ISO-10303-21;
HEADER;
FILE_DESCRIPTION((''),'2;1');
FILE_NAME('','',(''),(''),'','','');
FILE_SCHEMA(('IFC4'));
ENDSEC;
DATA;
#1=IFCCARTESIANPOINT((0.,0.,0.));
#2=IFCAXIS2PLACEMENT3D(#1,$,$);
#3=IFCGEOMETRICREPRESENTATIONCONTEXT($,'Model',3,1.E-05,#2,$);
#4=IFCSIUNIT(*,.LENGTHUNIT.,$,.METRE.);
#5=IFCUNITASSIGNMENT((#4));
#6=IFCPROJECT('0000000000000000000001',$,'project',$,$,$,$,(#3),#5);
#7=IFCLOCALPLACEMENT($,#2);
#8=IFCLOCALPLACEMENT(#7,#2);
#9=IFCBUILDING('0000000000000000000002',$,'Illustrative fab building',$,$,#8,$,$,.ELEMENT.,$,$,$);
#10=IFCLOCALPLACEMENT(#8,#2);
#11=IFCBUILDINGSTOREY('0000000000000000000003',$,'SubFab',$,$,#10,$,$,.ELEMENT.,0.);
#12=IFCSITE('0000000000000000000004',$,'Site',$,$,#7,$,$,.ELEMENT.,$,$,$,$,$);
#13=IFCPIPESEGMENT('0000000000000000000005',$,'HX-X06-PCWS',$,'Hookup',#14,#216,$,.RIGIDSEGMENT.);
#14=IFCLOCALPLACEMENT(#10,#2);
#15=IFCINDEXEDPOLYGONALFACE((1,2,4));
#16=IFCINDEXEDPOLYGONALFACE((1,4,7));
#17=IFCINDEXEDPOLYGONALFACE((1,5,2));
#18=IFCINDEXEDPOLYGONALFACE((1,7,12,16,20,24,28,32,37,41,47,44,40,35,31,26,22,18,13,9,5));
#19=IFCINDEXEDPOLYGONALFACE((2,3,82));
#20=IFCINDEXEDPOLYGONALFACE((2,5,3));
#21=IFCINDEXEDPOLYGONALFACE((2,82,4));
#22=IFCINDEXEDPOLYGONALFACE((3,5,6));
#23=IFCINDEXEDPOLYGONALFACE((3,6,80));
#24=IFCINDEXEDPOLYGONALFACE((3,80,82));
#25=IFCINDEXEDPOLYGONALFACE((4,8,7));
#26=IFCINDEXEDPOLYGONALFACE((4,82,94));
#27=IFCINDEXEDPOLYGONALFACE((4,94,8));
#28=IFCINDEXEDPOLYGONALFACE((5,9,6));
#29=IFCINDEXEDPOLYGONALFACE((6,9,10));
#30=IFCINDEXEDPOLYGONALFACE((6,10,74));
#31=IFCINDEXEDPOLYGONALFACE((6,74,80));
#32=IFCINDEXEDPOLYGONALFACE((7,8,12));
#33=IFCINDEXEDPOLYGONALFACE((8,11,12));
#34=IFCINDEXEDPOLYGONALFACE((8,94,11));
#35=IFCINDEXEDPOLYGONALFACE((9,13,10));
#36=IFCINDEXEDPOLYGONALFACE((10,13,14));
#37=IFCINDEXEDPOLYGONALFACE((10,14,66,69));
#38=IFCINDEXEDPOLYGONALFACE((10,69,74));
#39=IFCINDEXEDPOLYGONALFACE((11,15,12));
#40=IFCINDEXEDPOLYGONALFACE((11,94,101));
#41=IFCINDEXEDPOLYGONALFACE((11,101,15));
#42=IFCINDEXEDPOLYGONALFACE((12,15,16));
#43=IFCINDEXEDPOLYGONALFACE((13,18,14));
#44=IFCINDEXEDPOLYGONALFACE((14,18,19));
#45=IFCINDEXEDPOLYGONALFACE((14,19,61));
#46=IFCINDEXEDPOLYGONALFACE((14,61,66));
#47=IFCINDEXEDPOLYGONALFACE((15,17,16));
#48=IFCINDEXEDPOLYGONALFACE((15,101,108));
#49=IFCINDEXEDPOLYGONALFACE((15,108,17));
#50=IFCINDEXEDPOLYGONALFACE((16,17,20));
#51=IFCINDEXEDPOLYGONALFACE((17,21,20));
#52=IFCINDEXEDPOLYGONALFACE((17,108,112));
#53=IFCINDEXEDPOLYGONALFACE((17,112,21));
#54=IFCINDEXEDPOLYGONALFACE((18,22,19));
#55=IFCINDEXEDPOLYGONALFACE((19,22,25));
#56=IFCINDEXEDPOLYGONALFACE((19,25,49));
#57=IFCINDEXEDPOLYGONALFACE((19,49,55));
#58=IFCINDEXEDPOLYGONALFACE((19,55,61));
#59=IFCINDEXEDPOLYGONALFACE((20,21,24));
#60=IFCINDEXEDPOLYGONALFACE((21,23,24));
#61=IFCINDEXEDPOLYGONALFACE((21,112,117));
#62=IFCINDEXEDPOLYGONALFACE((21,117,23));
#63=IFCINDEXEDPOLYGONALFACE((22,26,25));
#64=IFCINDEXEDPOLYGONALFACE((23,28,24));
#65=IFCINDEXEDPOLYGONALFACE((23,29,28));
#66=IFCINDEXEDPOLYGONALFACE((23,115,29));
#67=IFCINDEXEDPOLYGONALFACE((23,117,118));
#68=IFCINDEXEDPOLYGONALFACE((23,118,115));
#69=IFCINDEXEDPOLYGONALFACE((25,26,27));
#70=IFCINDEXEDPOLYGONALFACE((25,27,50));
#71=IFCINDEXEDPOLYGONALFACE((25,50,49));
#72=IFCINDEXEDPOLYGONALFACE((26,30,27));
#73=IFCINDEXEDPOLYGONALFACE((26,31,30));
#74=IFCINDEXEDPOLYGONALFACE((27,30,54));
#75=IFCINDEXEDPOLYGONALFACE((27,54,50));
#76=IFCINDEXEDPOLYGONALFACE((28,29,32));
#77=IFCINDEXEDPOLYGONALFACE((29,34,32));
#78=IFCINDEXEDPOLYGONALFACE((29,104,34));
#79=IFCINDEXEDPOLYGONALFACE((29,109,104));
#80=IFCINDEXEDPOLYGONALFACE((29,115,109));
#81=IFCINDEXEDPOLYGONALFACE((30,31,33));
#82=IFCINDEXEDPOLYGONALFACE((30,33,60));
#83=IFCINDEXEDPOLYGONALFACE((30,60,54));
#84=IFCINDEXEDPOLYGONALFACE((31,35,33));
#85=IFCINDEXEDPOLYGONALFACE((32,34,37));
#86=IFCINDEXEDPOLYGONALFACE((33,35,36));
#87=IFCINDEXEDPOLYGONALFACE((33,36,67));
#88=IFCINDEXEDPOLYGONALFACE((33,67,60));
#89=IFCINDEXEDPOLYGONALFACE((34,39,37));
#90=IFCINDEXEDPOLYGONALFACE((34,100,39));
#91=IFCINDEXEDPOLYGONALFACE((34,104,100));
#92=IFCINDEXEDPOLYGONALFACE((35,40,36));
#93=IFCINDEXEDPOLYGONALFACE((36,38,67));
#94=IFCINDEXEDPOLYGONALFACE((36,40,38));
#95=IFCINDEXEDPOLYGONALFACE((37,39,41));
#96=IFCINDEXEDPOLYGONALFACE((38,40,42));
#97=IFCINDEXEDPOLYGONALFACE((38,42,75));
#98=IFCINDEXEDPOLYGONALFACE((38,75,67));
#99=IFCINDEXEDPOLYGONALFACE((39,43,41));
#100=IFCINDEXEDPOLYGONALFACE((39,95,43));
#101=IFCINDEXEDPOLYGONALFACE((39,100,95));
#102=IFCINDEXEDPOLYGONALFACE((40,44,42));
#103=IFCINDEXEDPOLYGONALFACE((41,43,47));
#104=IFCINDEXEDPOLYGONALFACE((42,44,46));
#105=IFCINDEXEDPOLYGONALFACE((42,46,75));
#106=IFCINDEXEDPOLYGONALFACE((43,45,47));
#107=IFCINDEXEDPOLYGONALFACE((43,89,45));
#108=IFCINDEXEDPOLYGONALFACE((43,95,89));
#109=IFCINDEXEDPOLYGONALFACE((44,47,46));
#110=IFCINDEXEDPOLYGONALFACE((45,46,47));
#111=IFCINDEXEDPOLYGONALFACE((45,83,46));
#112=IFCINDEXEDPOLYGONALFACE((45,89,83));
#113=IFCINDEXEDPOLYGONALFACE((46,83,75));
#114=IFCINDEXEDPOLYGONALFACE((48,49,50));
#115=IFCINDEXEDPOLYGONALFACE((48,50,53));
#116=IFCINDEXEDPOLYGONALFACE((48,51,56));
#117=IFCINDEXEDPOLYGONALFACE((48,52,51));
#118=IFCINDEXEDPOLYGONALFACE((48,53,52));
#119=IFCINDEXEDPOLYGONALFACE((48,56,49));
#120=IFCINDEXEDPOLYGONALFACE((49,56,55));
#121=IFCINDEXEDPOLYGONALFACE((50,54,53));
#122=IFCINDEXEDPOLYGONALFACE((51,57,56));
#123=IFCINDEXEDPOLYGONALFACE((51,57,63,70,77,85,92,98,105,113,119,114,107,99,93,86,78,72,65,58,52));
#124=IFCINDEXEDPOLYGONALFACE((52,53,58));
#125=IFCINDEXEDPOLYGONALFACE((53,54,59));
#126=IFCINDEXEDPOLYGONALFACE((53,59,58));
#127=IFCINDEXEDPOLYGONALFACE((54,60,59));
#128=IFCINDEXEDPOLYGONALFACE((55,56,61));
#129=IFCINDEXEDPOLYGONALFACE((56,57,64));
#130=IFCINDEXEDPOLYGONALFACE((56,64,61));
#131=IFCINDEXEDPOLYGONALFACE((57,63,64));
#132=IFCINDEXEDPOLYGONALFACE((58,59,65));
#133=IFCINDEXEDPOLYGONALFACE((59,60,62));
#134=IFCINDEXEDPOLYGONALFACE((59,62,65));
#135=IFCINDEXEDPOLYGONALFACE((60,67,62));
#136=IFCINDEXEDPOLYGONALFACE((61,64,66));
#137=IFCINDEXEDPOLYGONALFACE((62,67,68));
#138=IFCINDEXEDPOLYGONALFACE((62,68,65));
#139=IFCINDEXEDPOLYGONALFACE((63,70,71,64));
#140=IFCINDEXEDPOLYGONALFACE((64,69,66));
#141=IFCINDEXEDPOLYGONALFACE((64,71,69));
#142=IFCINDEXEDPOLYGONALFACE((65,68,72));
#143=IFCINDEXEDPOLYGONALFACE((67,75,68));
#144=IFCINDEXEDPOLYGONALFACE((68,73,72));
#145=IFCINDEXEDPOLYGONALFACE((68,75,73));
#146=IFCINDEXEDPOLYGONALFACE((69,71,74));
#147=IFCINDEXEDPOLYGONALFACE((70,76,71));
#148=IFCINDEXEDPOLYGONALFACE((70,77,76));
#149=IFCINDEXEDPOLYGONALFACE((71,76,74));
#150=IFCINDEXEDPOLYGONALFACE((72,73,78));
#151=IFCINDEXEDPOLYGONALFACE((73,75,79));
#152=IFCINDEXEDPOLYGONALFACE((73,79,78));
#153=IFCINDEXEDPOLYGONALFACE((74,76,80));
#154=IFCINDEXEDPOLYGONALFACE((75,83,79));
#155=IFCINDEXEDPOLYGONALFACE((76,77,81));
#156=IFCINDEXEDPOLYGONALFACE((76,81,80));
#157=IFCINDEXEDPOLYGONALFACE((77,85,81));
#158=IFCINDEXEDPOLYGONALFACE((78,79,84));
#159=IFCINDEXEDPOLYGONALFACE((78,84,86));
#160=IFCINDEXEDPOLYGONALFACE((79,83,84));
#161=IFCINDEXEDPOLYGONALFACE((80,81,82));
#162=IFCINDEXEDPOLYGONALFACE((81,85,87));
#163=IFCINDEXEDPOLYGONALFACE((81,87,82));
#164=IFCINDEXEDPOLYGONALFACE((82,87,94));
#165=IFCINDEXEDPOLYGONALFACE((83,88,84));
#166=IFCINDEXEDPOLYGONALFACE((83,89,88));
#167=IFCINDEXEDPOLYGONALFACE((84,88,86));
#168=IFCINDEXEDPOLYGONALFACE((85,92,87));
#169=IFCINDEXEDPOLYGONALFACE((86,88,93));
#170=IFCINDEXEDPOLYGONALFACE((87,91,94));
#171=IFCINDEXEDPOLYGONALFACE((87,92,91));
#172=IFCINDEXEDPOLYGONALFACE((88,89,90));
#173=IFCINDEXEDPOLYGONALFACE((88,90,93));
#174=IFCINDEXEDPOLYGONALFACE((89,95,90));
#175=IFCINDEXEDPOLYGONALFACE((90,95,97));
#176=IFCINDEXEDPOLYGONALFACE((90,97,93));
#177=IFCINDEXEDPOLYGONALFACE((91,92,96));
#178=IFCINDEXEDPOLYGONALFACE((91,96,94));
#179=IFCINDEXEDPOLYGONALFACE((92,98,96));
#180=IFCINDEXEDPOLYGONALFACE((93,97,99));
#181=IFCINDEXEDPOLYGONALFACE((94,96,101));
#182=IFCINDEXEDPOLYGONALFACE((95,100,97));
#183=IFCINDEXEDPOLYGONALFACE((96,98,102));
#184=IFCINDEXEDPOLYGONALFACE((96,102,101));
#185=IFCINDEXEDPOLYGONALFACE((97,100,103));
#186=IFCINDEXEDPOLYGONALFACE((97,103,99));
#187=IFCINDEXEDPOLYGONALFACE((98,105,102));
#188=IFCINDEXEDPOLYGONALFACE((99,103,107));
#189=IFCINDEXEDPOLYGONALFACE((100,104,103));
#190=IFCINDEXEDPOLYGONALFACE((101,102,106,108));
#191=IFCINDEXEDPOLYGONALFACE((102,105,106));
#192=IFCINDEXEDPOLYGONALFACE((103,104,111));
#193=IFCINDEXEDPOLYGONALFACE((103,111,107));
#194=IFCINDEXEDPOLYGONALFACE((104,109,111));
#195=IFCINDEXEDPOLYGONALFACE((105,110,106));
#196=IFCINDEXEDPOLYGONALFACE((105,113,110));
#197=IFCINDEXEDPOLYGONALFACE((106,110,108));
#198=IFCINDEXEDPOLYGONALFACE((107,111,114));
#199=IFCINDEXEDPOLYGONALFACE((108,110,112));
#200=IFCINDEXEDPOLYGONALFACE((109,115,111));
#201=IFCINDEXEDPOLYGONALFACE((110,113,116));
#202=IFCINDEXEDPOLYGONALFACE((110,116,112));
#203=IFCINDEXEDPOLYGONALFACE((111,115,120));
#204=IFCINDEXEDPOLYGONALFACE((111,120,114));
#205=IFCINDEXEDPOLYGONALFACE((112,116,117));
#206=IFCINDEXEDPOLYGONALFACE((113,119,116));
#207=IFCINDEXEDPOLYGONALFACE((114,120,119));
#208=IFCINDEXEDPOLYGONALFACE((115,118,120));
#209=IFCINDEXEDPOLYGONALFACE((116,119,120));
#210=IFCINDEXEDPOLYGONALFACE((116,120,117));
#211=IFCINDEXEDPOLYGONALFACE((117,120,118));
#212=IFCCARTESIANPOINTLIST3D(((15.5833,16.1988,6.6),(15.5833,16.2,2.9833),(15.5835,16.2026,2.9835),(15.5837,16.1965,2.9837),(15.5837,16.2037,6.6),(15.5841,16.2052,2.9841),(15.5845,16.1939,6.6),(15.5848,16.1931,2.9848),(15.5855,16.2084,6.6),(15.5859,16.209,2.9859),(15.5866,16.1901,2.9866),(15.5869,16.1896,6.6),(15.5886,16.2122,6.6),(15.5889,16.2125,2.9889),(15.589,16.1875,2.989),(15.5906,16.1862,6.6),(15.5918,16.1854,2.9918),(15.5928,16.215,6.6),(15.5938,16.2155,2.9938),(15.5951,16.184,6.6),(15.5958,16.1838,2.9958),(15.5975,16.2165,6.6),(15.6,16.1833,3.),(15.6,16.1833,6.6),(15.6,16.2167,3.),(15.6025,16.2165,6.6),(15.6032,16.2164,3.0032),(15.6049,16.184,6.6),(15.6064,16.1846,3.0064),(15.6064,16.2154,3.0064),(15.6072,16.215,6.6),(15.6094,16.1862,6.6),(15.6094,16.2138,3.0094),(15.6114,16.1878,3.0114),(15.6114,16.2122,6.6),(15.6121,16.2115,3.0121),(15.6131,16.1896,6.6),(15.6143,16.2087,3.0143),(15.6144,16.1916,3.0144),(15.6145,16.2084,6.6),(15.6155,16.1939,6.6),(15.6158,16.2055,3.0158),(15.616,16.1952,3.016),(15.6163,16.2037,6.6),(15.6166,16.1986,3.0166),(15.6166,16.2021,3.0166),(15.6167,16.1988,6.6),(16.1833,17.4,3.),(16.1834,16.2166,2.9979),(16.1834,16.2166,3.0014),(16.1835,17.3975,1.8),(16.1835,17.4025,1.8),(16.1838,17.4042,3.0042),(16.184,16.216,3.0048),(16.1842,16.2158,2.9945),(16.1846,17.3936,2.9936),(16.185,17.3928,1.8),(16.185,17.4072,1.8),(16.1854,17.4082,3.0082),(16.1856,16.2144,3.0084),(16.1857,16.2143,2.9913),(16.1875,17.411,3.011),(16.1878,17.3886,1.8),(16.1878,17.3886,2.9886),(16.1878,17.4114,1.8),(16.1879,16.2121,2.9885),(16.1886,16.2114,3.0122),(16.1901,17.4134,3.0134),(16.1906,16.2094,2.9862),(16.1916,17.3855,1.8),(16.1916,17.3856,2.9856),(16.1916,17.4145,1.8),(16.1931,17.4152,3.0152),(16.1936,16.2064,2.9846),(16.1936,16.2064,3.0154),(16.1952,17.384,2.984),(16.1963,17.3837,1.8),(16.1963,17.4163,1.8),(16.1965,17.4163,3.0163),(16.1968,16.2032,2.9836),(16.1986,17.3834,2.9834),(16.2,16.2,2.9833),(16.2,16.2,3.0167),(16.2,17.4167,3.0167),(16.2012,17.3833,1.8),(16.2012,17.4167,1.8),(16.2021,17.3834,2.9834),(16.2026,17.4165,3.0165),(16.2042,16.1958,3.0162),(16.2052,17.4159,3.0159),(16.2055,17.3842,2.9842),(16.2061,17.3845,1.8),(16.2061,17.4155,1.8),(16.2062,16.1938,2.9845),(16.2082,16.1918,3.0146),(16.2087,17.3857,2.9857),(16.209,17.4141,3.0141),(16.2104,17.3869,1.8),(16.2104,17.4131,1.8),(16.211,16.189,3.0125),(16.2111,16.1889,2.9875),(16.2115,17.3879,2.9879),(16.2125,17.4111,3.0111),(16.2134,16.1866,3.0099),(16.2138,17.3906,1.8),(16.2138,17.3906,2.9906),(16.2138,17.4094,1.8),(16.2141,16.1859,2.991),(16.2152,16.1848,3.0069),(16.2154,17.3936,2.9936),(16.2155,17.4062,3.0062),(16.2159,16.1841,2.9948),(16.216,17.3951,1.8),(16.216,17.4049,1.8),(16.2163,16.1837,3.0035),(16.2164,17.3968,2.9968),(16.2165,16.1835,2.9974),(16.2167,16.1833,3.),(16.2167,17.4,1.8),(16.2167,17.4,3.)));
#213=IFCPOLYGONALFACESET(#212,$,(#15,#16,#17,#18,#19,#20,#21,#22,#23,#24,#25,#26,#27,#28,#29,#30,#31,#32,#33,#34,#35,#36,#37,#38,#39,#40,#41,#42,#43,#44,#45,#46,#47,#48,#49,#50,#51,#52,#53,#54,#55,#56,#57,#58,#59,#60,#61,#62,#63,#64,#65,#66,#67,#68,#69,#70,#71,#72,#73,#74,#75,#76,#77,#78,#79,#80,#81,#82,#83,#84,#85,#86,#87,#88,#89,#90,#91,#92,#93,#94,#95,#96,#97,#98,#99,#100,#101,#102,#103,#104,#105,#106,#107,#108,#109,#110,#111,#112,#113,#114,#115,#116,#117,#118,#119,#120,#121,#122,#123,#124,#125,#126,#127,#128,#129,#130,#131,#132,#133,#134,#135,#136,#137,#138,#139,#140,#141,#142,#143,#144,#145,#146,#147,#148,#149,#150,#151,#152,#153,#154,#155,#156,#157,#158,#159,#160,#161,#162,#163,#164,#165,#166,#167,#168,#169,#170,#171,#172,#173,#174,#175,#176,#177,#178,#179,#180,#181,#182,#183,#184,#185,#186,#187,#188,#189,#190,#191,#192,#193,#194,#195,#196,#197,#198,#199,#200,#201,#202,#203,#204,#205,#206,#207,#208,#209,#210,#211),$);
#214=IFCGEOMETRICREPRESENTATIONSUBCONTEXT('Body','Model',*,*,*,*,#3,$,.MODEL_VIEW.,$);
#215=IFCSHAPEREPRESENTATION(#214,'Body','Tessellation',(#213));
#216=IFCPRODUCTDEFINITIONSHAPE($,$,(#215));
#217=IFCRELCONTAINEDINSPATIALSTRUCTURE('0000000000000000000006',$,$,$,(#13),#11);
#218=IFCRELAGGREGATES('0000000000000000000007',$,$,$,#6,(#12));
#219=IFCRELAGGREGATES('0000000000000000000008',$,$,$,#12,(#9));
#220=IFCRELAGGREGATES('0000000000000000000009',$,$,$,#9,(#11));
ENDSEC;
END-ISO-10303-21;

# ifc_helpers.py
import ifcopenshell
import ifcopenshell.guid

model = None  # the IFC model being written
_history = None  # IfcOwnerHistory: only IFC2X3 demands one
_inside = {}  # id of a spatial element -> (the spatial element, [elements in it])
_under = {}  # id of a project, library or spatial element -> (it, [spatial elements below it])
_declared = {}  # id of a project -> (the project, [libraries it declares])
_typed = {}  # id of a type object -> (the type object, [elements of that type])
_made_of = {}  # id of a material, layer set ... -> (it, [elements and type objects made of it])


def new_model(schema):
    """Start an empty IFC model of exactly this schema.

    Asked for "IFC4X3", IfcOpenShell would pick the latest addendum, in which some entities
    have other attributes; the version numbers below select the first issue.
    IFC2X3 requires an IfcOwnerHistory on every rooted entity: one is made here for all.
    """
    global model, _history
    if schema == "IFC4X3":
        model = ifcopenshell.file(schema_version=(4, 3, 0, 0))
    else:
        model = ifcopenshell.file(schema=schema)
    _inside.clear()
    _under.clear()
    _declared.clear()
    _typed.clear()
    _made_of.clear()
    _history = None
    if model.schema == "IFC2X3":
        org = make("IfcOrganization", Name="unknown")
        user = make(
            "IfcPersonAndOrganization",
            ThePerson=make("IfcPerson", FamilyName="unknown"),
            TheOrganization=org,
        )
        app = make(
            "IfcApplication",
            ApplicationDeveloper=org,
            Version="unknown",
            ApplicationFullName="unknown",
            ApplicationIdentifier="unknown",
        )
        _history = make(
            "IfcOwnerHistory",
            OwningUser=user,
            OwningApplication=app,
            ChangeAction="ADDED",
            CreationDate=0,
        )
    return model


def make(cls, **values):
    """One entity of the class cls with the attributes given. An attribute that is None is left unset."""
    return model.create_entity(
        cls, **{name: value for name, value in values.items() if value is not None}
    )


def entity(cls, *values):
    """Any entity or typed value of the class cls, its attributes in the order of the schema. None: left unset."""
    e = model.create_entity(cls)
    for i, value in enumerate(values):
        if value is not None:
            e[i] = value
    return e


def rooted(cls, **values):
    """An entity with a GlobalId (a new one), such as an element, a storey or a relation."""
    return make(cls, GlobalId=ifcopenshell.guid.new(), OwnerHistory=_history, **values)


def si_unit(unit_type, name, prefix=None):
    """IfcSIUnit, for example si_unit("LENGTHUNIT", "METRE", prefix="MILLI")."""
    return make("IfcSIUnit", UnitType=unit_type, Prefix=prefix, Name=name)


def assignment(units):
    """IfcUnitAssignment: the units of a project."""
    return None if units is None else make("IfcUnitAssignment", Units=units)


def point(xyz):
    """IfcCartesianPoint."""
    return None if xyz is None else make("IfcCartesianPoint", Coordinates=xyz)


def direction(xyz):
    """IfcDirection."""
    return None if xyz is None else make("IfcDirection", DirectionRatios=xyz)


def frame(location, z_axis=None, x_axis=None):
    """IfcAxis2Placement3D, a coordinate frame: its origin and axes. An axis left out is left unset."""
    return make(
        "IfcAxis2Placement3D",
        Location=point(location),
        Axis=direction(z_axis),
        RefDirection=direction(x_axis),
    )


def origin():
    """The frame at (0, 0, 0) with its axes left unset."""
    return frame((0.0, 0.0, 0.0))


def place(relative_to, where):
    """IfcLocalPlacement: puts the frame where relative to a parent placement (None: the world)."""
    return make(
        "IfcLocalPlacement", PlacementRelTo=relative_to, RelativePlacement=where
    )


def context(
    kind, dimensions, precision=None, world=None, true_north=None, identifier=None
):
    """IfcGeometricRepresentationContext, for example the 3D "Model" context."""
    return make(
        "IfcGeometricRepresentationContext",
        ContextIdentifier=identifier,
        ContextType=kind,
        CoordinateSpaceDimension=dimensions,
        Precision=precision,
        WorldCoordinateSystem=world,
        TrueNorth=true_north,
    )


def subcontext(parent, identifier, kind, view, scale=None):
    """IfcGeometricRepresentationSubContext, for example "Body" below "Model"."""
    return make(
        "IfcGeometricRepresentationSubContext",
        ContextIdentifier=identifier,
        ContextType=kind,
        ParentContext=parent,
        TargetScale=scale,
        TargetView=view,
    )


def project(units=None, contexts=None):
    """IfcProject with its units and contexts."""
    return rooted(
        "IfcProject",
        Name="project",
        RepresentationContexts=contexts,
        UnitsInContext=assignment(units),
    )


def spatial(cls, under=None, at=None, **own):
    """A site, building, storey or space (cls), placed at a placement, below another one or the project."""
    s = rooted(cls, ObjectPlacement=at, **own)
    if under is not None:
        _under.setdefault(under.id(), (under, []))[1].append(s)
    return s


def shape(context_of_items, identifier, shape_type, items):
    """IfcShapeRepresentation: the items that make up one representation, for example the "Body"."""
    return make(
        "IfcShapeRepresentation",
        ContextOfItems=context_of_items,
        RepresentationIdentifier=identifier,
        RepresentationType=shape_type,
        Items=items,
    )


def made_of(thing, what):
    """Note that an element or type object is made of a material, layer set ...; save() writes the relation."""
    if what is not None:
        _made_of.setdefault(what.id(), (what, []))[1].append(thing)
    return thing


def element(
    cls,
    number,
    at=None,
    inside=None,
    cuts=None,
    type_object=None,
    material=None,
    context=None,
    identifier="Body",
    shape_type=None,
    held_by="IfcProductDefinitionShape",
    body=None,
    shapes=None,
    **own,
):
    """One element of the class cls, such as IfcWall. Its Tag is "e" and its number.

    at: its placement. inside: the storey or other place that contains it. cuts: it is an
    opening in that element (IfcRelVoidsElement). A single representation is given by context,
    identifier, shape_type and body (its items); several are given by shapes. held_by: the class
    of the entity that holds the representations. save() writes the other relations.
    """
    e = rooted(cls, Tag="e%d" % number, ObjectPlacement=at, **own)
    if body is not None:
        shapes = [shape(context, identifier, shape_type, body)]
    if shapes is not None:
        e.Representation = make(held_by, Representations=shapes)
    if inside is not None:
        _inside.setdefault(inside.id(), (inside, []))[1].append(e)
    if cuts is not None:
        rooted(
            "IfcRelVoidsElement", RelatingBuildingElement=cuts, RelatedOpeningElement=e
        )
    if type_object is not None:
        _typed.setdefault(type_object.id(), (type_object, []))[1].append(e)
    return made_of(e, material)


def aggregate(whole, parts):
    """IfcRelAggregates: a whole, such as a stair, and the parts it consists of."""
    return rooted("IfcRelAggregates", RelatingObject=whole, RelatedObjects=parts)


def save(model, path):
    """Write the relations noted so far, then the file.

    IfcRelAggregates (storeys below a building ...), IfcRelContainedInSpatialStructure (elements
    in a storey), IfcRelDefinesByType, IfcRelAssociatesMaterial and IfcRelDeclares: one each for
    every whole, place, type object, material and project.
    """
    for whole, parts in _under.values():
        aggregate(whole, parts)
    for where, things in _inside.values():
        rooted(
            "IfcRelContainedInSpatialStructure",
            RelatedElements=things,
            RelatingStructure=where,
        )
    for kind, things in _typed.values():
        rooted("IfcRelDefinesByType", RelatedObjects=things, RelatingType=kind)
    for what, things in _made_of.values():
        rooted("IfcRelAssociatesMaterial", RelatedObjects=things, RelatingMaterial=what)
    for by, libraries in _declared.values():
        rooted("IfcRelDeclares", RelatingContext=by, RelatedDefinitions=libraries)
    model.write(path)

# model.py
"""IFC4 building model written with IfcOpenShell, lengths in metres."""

from ifc_helpers import new_model, entity, si_unit, origin, place, context, subcontext, project, spatial, element, save


model = new_model("IFC4")

# Units and contexts
model_context = context("Model", 3, precision=1e-05, world=origin())
body_context = subcontext(model_context, "Body", "Model", "MODEL_VIEW")
ifc_project = project(units=[si_unit("LENGTHUNIT", "METRE")], contexts=[model_context])

# Site, building, storey
site_placement = place(None, origin())
site = spatial("IfcSite", under=ifc_project, at=site_placement, Name="Site", CompositionType="ELEMENT")
building_placement = place(site_placement, origin())
building = spatial("IfcBuilding", under=site, at=building_placement, Name="Illustrative fab building", CompositionType="ELEMENT")
storey_placement = place(building_placement, origin())
storey = spatial("IfcBuildingStorey", under=building, at=storey_placement, Name="SubFab", CompositionType="ELEMENT", Elevation=0.0)

# Pipe segment
pipe_segment_1_placement = place(storey_placement, origin())
element("IfcPipeSegment", 1, at=pipe_segment_1_placement, inside=storey, Name="HX-X06-PCWS", ObjectType="Hookup", PredefinedType="RIGIDSEGMENT", context=body_context, shape_type="AdvancedSweptSolid", body=[
    entity("IfcSweptDiskSolid", entity("IfcPolyline", [entity("IfcCartesianPoint", [16.2, 17.4, 1.8]), entity("IfcCartesianPoint", [16.2, 17.4, 3.0]), entity("IfcCartesianPoint", [16.2, 16.2, 3.0]), entity("IfcCartesianPoint", [15.6, 16.2, 3.0]), entity("IfcCartesianPoint", [15.6, 16.2, 6.6])]), 0.0167),
])

save(model, "model.ifc")
